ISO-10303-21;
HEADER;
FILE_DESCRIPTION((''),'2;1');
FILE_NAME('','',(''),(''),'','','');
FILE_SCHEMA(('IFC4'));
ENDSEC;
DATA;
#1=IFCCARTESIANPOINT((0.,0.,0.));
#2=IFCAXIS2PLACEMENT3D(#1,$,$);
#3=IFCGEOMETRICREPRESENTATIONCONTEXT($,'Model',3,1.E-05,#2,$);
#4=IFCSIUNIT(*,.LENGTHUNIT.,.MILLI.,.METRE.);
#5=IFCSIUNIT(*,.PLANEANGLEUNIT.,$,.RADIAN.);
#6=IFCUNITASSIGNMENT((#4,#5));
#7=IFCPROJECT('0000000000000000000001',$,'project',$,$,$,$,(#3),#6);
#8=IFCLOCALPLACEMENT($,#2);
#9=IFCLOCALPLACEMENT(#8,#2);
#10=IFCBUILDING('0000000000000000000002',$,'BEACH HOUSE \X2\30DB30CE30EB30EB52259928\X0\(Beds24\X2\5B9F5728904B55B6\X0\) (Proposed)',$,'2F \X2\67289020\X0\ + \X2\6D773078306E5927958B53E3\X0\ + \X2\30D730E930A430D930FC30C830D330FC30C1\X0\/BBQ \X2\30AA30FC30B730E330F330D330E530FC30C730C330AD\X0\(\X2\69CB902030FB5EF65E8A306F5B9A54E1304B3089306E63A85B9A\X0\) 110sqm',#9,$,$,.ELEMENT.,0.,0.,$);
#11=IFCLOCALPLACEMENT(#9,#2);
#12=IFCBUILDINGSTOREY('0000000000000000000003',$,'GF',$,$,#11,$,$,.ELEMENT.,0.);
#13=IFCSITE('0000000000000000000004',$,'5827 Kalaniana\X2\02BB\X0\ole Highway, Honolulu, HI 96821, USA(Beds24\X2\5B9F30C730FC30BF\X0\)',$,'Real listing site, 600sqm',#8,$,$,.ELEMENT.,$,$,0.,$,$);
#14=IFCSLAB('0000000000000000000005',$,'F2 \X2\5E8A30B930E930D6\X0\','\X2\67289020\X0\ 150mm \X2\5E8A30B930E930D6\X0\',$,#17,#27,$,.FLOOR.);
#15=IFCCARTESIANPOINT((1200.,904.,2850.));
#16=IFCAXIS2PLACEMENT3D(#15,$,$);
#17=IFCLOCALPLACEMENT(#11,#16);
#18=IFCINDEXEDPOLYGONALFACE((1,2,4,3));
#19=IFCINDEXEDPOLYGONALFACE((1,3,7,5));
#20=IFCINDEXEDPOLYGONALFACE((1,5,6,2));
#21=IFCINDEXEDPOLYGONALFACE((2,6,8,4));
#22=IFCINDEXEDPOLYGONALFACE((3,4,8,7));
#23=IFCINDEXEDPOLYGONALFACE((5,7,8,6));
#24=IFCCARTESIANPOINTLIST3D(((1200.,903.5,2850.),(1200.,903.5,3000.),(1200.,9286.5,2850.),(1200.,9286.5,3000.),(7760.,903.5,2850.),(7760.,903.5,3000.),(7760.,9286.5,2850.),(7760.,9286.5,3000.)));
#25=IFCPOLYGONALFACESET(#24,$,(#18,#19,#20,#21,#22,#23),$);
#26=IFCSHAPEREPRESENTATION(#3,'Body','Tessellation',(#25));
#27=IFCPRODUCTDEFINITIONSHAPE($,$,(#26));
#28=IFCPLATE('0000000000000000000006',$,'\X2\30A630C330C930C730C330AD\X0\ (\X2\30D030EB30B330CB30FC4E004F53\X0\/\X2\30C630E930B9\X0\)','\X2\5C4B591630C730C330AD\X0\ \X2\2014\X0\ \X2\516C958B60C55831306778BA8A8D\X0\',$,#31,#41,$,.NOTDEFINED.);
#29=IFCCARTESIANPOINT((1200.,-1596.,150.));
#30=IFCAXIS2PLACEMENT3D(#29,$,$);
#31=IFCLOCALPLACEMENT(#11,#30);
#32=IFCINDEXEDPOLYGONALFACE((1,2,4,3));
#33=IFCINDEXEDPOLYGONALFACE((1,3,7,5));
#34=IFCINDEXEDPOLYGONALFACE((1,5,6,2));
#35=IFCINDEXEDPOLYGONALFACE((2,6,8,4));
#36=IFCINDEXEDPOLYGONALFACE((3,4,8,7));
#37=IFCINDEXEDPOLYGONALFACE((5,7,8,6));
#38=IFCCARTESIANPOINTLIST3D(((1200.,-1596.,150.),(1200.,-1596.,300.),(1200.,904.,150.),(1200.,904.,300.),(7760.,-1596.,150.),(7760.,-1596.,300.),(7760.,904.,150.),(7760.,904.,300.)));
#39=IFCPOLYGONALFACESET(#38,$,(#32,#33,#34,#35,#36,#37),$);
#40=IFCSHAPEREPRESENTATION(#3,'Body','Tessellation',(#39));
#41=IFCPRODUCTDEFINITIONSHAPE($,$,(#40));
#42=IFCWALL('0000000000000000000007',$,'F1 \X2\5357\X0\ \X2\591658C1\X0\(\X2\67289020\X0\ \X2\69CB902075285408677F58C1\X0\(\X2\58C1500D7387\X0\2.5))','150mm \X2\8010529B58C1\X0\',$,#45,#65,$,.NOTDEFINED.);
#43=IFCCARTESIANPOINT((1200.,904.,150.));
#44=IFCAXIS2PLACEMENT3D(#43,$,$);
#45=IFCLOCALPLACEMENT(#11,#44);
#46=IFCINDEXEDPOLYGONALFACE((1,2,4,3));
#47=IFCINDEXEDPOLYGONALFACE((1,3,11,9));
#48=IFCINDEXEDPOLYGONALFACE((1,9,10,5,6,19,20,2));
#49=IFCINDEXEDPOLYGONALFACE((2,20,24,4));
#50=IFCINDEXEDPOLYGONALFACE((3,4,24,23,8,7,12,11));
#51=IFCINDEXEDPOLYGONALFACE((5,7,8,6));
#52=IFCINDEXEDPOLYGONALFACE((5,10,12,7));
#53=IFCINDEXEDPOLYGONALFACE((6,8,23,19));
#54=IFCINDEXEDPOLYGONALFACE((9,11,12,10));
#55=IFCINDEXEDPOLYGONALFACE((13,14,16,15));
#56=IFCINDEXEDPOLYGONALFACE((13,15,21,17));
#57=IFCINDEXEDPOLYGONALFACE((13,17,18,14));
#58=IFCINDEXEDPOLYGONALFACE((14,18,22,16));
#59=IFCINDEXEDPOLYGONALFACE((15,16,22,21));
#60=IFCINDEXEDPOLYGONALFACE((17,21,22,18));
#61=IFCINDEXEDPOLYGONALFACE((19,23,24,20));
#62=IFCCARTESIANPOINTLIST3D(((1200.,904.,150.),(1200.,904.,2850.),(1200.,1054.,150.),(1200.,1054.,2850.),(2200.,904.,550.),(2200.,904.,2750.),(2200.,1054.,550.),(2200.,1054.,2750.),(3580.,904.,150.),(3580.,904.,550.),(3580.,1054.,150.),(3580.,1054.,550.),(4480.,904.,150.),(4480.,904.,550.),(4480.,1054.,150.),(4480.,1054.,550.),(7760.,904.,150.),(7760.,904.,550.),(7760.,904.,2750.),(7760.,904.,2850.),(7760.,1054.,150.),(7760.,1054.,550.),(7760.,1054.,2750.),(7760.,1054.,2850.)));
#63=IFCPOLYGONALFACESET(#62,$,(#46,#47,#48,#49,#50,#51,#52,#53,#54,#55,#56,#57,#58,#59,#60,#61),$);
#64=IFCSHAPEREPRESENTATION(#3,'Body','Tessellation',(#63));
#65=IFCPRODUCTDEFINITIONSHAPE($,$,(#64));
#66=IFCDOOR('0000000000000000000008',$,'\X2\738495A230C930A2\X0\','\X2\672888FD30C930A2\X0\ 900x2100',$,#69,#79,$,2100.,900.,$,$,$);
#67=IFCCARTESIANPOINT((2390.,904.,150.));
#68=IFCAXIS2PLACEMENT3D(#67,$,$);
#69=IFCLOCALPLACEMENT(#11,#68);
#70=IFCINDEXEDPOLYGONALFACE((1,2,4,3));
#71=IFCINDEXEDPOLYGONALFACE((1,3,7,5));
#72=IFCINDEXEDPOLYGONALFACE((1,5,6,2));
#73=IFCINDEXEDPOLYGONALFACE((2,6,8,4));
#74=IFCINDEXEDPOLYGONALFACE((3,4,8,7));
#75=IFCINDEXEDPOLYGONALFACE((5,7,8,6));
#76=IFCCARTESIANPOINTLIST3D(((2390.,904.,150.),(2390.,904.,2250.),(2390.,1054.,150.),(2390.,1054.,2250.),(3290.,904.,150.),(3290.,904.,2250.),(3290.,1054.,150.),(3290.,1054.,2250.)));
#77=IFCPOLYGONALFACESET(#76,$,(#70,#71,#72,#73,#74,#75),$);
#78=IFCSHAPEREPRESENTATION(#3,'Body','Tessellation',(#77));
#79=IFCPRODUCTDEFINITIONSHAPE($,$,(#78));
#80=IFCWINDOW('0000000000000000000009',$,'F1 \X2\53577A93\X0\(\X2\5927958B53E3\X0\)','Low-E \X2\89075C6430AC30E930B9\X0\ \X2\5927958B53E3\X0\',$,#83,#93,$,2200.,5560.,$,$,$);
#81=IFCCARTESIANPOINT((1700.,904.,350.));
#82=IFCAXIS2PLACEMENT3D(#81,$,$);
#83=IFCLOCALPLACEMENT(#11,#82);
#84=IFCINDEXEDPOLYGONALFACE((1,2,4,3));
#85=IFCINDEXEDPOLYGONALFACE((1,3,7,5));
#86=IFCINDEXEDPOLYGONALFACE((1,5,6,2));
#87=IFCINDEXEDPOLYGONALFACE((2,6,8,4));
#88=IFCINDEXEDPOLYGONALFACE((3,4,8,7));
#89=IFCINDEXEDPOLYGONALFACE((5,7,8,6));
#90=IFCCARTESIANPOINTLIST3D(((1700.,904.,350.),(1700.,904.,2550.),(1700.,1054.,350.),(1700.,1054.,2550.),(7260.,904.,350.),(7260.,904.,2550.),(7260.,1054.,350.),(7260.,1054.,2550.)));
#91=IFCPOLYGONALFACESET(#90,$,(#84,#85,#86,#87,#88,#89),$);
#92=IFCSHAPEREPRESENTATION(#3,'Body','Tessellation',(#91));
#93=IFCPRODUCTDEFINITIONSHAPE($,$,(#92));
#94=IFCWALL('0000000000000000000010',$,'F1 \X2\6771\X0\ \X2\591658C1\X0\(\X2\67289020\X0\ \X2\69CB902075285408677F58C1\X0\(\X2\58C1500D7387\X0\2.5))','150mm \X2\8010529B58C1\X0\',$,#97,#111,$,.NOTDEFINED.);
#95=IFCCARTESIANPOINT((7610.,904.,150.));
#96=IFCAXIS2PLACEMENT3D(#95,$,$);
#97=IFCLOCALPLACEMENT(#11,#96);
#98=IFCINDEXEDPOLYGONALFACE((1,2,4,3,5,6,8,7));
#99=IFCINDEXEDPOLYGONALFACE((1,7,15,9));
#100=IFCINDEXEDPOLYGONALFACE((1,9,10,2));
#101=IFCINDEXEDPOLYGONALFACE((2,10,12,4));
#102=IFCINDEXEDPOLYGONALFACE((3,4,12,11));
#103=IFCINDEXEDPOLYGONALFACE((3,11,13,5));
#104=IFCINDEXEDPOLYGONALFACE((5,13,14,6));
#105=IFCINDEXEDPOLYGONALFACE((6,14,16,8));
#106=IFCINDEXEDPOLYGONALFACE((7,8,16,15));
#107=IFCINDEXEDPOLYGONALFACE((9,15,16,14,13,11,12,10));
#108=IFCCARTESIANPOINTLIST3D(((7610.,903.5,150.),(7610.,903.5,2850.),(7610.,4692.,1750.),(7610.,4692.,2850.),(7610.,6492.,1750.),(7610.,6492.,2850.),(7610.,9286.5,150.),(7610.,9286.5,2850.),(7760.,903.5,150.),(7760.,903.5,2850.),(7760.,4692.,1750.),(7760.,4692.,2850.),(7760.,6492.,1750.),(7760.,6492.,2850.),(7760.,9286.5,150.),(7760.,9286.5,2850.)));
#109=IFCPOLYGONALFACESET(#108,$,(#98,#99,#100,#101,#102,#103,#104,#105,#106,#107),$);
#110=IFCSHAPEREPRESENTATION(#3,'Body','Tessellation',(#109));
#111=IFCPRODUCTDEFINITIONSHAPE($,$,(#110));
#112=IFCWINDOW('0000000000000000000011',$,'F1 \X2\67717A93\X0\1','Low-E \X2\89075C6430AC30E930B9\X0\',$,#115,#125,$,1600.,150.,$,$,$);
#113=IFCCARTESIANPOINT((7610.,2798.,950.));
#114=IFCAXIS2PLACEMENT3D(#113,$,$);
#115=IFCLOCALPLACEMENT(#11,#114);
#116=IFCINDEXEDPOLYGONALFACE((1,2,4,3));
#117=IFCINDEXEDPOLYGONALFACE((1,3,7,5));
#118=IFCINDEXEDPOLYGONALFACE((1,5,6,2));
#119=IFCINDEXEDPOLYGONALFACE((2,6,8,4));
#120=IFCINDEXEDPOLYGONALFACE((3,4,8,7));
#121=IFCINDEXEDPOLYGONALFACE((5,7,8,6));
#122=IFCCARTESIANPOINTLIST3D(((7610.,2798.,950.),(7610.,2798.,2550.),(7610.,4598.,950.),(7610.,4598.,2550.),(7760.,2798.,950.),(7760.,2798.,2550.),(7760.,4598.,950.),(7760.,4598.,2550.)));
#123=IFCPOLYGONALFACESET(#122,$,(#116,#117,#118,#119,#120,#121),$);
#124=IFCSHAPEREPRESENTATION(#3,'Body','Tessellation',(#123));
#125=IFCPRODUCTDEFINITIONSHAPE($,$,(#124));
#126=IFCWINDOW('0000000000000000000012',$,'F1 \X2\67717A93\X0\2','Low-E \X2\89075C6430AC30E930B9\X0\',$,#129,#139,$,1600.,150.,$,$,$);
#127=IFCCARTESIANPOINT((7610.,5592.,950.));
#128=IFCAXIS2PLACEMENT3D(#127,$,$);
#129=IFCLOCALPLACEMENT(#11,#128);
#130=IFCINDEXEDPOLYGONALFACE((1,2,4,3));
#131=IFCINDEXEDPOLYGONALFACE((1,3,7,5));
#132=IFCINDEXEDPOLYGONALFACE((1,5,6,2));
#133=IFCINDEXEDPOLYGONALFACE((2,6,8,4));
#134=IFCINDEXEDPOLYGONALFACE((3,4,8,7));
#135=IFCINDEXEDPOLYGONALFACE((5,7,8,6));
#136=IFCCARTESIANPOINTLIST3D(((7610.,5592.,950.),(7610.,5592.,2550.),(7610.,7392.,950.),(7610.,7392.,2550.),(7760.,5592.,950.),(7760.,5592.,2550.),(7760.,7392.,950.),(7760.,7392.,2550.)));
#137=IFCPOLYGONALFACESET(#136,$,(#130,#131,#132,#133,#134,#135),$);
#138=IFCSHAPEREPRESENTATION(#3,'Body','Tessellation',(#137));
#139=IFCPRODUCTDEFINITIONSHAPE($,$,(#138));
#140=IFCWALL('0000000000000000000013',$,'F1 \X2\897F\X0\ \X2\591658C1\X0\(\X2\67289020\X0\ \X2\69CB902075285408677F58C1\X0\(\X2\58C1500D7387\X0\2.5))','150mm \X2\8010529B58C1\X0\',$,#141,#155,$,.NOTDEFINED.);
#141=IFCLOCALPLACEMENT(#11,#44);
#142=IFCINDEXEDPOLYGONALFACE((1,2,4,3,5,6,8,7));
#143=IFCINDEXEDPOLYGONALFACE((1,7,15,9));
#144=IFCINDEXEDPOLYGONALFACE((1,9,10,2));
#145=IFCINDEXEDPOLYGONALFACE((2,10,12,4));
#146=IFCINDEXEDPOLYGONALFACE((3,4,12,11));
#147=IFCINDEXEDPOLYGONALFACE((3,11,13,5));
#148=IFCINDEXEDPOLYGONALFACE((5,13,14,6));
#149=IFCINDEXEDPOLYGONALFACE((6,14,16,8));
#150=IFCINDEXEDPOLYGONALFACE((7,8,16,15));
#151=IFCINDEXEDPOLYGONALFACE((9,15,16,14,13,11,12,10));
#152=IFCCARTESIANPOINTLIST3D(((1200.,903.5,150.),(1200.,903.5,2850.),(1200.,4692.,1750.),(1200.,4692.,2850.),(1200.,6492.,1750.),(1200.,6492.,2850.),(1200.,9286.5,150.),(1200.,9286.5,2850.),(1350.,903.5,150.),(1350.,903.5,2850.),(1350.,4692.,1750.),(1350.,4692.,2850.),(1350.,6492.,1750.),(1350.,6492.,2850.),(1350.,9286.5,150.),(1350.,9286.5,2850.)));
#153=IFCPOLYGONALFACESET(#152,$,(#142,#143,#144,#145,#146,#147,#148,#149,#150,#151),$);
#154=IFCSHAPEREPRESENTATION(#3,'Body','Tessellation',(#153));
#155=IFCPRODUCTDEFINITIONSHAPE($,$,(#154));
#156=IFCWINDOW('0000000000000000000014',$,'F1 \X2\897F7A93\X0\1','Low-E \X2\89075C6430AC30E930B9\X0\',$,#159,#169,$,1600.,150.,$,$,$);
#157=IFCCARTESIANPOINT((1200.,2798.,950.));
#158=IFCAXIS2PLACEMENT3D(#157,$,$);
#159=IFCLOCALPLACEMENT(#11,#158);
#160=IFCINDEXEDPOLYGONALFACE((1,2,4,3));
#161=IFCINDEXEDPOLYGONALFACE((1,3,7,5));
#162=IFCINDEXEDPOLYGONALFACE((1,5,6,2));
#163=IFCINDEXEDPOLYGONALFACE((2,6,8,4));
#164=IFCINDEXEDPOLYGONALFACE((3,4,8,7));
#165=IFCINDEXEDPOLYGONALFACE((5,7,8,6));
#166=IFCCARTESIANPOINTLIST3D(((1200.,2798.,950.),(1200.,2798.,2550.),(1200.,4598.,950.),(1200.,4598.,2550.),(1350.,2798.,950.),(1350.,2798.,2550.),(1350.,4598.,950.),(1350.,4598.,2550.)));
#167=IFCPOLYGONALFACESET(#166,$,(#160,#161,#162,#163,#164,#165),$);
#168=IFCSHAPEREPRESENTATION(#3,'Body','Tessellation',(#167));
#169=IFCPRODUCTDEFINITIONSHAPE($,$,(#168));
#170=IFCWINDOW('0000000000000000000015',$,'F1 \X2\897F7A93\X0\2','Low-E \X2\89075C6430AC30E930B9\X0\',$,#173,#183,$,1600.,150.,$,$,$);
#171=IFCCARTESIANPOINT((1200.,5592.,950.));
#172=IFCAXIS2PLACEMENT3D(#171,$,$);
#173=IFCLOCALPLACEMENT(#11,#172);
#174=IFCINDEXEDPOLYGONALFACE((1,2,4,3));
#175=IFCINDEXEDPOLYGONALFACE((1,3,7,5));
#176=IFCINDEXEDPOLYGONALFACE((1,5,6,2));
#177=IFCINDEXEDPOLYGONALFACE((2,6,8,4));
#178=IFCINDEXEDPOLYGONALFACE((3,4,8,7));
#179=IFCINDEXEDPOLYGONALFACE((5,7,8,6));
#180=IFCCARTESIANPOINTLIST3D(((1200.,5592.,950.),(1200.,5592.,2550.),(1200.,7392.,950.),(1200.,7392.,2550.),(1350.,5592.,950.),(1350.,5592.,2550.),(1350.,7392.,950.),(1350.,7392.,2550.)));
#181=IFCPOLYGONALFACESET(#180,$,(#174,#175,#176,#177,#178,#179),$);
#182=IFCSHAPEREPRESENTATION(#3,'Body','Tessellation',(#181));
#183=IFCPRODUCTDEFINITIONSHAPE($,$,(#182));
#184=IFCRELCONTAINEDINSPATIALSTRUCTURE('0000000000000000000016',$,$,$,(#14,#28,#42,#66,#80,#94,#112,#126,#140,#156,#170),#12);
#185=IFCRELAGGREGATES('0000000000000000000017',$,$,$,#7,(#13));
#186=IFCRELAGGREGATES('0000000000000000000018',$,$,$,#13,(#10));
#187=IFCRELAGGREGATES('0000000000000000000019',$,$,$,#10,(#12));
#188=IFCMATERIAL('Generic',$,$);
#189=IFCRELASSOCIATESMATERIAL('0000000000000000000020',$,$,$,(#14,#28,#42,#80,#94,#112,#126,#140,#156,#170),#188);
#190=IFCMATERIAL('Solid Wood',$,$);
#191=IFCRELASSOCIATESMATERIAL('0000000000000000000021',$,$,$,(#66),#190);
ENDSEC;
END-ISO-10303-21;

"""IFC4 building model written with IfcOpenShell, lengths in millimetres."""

from ifc_helpers import new_model, si_unit, frame, frame_2d, origin, place, context, project, spatial, rectangle, extrude, material, element, fill, save


model = new_model("IFC4")

# Units and contexts
model_context = context("Model", 3, precision=1e-05, world=origin())
ifc_project = project(units=[si_unit("LENGTHUNIT", "METRE", prefix="MILLI"), si_unit("PLANEANGLEUNIT", "RADIAN")], contexts=[model_context])

# Site, building, storey
site_placement = place(None, origin())
site = spatial("IfcSite", under=ifc_project, at=site_placement, Name="5827 Kalanianaʻole Highway, Honolulu, HI 96821, USA(Beds24実データ)", ObjectType="Real listing site, 600sqm", CompositionType="ELEMENT", RefElevation=0.0)
building_placement = place(site_placement, origin())
building = spatial("IfcBuilding", under=site, at=building_placement, Name="BEACH HOUSE ホノルル別館(Beds24実在運営) (Proposed)", ObjectType="2F 木造 + 海への大開口 + プライベートビーチ/BBQ オーシャンビューデッキ(構造・延床は定員からの推定) 110sqm", CompositionType="ELEMENT", ElevationOfRefHeight=0.0, ElevationOfTerrain=0.0)
storey_placement = place(building_placement, origin())
storey = spatial("IfcBuildingStorey", under=building, at=storey_placement, Name="GF", CompositionType="ELEMENT", Elevation=0.0)

# Slab
ifc_material_1 = material(Name="Generic")
slab_1_placement = place(storey_placement, frame((1200.0, 904.0, 2850.0)))
element("IfcSlab", 1, at=slab_1_placement, inside=storey, material=ifc_material_1, Name="F2 床スラブ", Description="木造 150mm 床スラブ", PredefinedType="FLOOR", context=model_context, shape_type="SweptSolid", body=[
    extrude(rectangle(XDim=6560.0, YDim=8383.0, at=frame_2d((3280.0, 4191.0))), frame((1200.0, 904.0, 2850.0)), (0.0, 0.0, 1.0), 150.0),
])

# Plate
plate_placement = place(storey_placement, frame((1200.0, -1596.0, 150.0)))
element("IfcPlate", 2, at=plate_placement, inside=storey, material=ifc_material_1, Name="ウッドデッキ (バルコニー一体/テラス)", Description="屋外デッキ — 公開情報で確認", PredefinedType="NOTDEFINED", context=model_context, shape_type="SweptSolid", body=[
    extrude(rectangle(XDim=6560.0, YDim=2500.0, at=frame_2d((3280.0, 1250.0))), frame((1200.0, -1596.0, 150.0)), (0.0, 0.0, 1.0), 150.0),
])

# Wall, openings, door, window
wall_1_placement = place(storey_placement, frame((1200.0, 904.0, 150.0)))
wall_1 = element("IfcWall", 3, at=wall_1_placement, inside=storey, material=ifc_material_1, Name="F1 南 外壁(木造 構造用合板壁(壁倍率2.5))", Description="150mm 耐力壁", PredefinedType="NOTDEFINED", context=model_context, shape_type="SweptSolid", body=[
    extrude(rectangle(XDim=6560.0, YDim=150.0, at=frame_2d((3280.0, 75.0))), frame((1200.0, 904.0, 150.0)), (0.0, 0.0, 1.0), 2700.0),
])
opening_1_placement = place(storey_placement, frame((2390.0, 904.0, 150.0)))
opening_1 = element("IfcOpeningElement", 4, at=opening_1_placement, cuts=wall_1, PredefinedType="NOTDEFINED", context=model_context, shape_type="SweptSolid", body=[
    extrude(rectangle(XDim=900.0, YDim=150.0, at=frame_2d((450.0, 75.0))), frame((2390.0, 904.0, 150.0)), (0.0, 0.0, 1.0), 2100.0),
])
opening_2_placement = place(storey_placement, frame((1700.0, 904.0, 350.0)))
opening_2 = element("IfcOpeningElement", 5, at=opening_2_placement, cuts=wall_1, PredefinedType="NOTDEFINED", context=model_context, shape_type="SweptSolid", body=[
    extrude(rectangle(XDim=5560.0, YDim=150.0, at=frame_2d((2780.0, 75.0))), frame((1700.0, 904.0, 350.0)), (0.0, 0.0, 1.0), 2200.0),
])
ifc_material_2 = material(Name="Solid Wood")
door_placement = place(storey_placement, frame((2390.0, 904.0, 150.0)))
door = element("IfcDoor", 6, at=door_placement, inside=storey, material=ifc_material_2, Name="玄関ドア", Description="木製ドア 900x2100", OverallHeight=2100.0, OverallWidth=900.0, context=model_context, shape_type="SweptSolid", body=[
    extrude(rectangle(XDim=900.0, YDim=150.0, at=frame_2d((450.0, 75.0))), frame((2390.0, 904.0, 150.0)), (0.0, 0.0, 1.0), 2100.0),
])
fill(opening_1, door)
window_1_placement = place(storey_placement, frame((1700.0, 904.0, 350.0)))
window_1 = element("IfcWindow", 7, at=window_1_placement, inside=storey, material=ifc_material_1, Name="F1 南窓(大開口)", Description="Low-E 複層ガラス 大開口", OverallHeight=2200.0, OverallWidth=5560.0, context=model_context, shape_type="SweptSolid", body=[
    extrude(rectangle(XDim=5560.0, YDim=150.0, at=frame_2d((2780.0, 75.0))), frame((1700.0, 904.0, 350.0)), (0.0, 0.0, 1.0), 2200.0),
])
fill(opening_2, window_1)

# Walls, openings, windows
wall_2_placement = place(storey_placement, frame((7610.0, 904.0, 150.0)))
wall_2 = element("IfcWall", 8, at=wall_2_placement, inside=storey, material=ifc_material_1, Name="F1 東 外壁(木造 構造用合板壁(壁倍率2.5))", Description="150mm 耐力壁", PredefinedType="NOTDEFINED", context=model_context, shape_type="SweptSolid", body=[
    extrude(rectangle(XDim=150.0, YDim=8383.0, at=frame_2d((75.0, 4191.0))), frame((7610.0, 904.0, 150.0)), (0.0, 0.0, 1.0), 2700.0),
])
opening_3_placement = place(storey_placement, frame((7610.0, 2798.0, 950.0)))
opening_3 = element("IfcOpeningElement", 9, at=opening_3_placement, cuts=wall_2, PredefinedType="NOTDEFINED", context=model_context, shape_type="SweptSolid", body=[
    extrude(rectangle(XDim=150.0, YDim=1800.0, at=frame_2d((75.0, 900.0))), frame((7610.0, 2798.0, 950.0)), (0.0, 0.0, 1.0), 1600.0),
])
opening_4_placement = place(storey_placement, frame((7610.0, 5592.0, 950.0)))
opening_4 = element("IfcOpeningElement", 10, at=opening_4_placement, cuts=wall_2, PredefinedType="NOTDEFINED", context=model_context, shape_type="SweptSolid", body=[
    extrude(rectangle(XDim=150.0, YDim=1800.0, at=frame_2d((75.0, 900.0))), frame((7610.0, 5592.0, 950.0)), (0.0, 0.0, 1.0), 1600.0),
])
window_2_placement = place(storey_placement, frame((7610.0, 2798.0, 950.0)))
window_2 = element("IfcWindow", 11, at=window_2_placement, inside=storey, material=ifc_material_1, Name="F1 東窓1", Description="Low-E 複層ガラス", OverallHeight=1600.0, OverallWidth=150.0, context=model_context, shape_type="SweptSolid", body=[
    extrude(rectangle(XDim=150.0, YDim=1800.0, at=frame_2d((75.0, 900.0))), frame((7610.0, 2798.0, 950.0)), (0.0, 0.0, 1.0), 1600.0),
])
fill(opening_3, window_2)
window_3_placement = place(storey_placement, frame((7610.0, 5592.0, 950.0)))
window_3 = element("IfcWindow", 12, at=window_3_placement, inside=storey, material=ifc_material_1, Name="F1 東窓2", Description="Low-E 複層ガラス", OverallHeight=1600.0, OverallWidth=150.0, context=model_context, shape_type="SweptSolid", body=[
    extrude(rectangle(XDim=150.0, YDim=1800.0, at=frame_2d((75.0, 900.0))), frame((7610.0, 5592.0, 950.0)), (0.0, 0.0, 1.0), 1600.0),
])
fill(opening_4, window_3)
wall_3_placement = place(storey_placement, frame((1200.0, 904.0, 150.0)))
wall_3 = element("IfcWall", 13, at=wall_3_placement, inside=storey, material=ifc_material_1, Name="F1 西 外壁(木造 構造用合板壁(壁倍率2.5))", Description="150mm 耐力壁", PredefinedType="NOTDEFINED", context=model_context, shape_type="SweptSolid", body=[
    extrude(rectangle(XDim=150.0, YDim=8383.0, at=frame_2d((75.0, 4191.0))), frame((1200.0, 904.0, 150.0)), (0.0, 0.0, 1.0), 2700.0),
])
opening_5_placement = place(storey_placement, frame((1200.0, 2798.0, 950.0)))
opening_5 = element("IfcOpeningElement", 14, at=opening_5_placement, cuts=wall_3, PredefinedType="NOTDEFINED", context=model_context, shape_type="SweptSolid", body=[
    extrude(rectangle(XDim=150.0, YDim=1800.0, at=frame_2d((75.0, 900.0))), frame((1200.0, 2798.0, 950.0)), (0.0, 0.0, 1.0), 1600.0),
])
opening_6_placement = place(storey_placement, frame((1200.0, 5592.0, 950.0)))
opening_6 = element("IfcOpeningElement", 15, at=opening_6_placement, cuts=wall_3, PredefinedType="NOTDEFINED", context=model_context, shape_type="SweptSolid", body=[
    extrude(rectangle(XDim=150.0, YDim=1800.0, at=frame_2d((75.0, 900.0))), frame((1200.0, 5592.0, 950.0)), (0.0, 0.0, 1.0), 1600.0),
])
window_4_placement = place(storey_placement, frame((1200.0, 2798.0, 950.0)))
window_4 = element("IfcWindow", 16, at=window_4_placement, inside=storey, material=ifc_material_1, Name="F1 西窓1", Description="Low-E 複層ガラス", OverallHeight=1600.0, OverallWidth=150.0, context=model_context, shape_type="SweptSolid", body=[
    extrude(rectangle(XDim=150.0, YDim=1800.0, at=frame_2d((75.0, 900.0))), frame((1200.0, 2798.0, 950.0)), (0.0, 0.0, 1.0), 1600.0),
])
fill(opening_5, window_4)
window_5_placement = place(storey_placement, frame((1200.0, 5592.0, 950.0)))
window_5 = element("IfcWindow", 17, at=window_5_placement, inside=storey, material=ifc_material_1, Name="F1 西窓2", Description="Low-E 複層ガラス", OverallHeight=1600.0, OverallWidth=150.0, context=model_context, shape_type="SweptSolid", body=[
    extrude(rectangle(XDim=150.0, YDim=1800.0, at=frame_2d((75.0, 900.0))), frame((1200.0, 5592.0, 950.0)), (0.0, 0.0, 1.0), 1600.0),
])
fill(opening_6, window_5)

save(model, "model.ifc")
